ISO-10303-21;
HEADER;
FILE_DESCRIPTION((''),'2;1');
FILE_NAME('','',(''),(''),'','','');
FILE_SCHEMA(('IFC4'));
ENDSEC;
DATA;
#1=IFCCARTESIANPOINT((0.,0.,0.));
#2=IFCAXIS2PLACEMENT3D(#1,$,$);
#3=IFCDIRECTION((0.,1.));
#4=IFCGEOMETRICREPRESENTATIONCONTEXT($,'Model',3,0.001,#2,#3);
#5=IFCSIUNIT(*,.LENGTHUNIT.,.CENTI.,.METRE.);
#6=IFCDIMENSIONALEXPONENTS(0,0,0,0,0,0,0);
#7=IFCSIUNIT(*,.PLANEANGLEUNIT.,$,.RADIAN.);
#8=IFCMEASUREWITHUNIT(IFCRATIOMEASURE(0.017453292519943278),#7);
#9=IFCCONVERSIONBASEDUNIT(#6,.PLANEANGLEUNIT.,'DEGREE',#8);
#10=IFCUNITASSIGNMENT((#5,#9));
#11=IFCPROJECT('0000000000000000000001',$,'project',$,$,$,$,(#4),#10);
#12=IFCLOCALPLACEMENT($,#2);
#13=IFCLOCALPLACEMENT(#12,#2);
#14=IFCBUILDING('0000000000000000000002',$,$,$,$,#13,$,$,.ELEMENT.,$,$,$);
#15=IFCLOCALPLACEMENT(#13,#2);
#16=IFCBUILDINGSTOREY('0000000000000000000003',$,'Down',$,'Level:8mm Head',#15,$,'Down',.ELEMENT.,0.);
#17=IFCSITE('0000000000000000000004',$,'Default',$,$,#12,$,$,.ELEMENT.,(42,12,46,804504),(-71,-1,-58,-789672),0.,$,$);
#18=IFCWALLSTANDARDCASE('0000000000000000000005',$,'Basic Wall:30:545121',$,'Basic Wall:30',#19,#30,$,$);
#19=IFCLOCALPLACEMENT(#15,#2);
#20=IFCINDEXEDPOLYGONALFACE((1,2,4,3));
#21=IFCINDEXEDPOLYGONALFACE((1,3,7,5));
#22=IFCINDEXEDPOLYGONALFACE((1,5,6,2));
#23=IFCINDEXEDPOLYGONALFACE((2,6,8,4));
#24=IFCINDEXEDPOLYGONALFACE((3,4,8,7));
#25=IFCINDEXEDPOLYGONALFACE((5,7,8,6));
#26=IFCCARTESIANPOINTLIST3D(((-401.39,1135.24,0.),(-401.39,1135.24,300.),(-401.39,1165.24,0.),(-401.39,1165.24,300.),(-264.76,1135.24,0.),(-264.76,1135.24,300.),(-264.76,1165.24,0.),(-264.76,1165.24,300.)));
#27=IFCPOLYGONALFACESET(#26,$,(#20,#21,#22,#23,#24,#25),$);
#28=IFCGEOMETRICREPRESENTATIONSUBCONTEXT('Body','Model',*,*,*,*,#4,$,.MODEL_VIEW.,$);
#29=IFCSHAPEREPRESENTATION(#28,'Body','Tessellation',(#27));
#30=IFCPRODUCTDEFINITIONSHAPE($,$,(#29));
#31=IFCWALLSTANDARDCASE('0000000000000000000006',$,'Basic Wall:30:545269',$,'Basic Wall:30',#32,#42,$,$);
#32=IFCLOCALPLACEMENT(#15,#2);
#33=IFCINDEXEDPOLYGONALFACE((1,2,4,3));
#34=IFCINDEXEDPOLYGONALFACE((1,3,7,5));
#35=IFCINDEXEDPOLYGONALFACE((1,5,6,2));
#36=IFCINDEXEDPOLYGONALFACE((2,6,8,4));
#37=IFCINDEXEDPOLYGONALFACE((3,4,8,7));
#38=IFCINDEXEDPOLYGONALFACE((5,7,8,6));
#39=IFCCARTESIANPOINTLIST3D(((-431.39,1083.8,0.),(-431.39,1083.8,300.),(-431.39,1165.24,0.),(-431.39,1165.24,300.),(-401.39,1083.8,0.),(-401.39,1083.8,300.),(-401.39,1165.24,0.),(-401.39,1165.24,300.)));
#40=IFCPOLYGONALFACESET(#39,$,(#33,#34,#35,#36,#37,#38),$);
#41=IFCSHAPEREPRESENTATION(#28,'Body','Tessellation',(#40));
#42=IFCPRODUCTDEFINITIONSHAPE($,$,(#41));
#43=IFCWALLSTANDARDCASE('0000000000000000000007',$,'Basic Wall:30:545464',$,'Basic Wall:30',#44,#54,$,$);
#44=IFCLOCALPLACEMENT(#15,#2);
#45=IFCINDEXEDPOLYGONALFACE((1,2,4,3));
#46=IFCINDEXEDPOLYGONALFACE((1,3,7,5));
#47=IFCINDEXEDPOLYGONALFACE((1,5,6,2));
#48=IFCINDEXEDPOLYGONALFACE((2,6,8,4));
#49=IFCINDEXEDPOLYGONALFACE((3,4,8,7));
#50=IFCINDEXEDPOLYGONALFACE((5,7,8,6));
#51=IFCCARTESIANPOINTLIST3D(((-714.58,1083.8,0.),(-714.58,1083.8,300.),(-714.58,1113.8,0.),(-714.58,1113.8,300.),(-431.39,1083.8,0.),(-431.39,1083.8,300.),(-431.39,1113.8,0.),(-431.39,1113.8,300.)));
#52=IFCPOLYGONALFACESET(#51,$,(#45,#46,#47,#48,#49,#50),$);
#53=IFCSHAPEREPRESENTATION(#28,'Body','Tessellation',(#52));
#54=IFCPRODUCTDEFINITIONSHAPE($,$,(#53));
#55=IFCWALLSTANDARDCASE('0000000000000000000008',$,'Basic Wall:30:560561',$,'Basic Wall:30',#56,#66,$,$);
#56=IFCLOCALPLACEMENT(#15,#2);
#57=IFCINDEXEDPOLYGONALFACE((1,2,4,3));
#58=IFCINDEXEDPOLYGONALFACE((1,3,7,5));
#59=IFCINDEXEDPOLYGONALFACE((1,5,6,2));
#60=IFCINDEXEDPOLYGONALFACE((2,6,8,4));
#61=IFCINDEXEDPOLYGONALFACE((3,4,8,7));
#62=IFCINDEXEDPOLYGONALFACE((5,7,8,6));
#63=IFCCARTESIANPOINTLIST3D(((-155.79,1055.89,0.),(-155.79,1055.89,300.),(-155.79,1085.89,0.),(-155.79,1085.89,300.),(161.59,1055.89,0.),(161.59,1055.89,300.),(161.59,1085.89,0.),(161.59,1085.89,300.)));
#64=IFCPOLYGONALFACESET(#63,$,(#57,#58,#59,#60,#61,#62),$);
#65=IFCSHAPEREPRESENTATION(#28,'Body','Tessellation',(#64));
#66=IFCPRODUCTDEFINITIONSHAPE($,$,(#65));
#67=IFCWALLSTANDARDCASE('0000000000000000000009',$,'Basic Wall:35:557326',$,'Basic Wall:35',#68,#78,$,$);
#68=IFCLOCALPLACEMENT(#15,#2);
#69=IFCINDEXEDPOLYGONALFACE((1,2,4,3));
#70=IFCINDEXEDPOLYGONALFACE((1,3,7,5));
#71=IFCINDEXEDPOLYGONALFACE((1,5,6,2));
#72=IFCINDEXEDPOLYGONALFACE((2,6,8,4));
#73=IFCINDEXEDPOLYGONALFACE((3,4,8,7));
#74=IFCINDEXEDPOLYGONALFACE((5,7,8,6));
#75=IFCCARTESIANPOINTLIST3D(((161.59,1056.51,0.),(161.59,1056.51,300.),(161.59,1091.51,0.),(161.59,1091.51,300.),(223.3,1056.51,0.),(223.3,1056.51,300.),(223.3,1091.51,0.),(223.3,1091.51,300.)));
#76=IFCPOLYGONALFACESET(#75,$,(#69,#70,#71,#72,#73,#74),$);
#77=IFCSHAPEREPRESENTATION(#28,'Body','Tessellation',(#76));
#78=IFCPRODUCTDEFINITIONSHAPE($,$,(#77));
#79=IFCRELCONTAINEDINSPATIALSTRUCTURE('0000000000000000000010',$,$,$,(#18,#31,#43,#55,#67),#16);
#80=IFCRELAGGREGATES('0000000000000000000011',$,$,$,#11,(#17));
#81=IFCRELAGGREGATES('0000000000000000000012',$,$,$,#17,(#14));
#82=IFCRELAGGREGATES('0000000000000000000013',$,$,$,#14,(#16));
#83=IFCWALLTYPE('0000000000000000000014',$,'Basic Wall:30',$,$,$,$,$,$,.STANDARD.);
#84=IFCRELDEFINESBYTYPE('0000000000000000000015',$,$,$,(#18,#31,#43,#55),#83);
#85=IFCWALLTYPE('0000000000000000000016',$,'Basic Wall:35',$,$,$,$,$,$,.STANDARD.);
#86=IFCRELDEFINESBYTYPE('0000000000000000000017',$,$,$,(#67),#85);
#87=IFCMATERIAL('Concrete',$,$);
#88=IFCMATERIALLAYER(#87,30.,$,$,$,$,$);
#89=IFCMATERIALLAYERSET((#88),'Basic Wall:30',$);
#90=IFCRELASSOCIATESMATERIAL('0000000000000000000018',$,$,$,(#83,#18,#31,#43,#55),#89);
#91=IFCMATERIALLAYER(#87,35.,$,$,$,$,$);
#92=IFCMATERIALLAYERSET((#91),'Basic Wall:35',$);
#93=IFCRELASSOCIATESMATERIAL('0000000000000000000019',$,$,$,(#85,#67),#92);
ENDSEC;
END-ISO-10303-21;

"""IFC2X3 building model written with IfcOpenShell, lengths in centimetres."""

from ifc_helpers import new_model, entity, si_unit, converted_unit, direction, frame, frame_2d, origin, place, context, subcontext, project, spatial, rectangle, extrude, material, layer, layer_set, layer_usage, type_object, element, save


model = new_model("IFC2X3")

# Units and contexts
model_context = context("Model", 3, precision=0.001, world=origin(), true_north=direction((0.0, 1.0)))
body_context = subcontext(model_context, "Body", "Model", "MODEL_VIEW")
ifc_project = project(units=[si_unit("LENGTHUNIT", "METRE", prefix="CENTI"), converted_unit("PLANEANGLEUNIT", "DEGREE", entity("IfcRatioMeasure", 0.017453292519943278), si_unit("PLANEANGLEUNIT", "RADIAN"), dimensions=[0, 0, 0, 0, 0, 0, 0])], contexts=[model_context])

# Site, building, storey
site_placement = place(None, origin())
site = spatial("IfcSite", under=ifc_project, at=site_placement, Name="Default", CompositionType="ELEMENT", RefLatitude=(42, 12, 46, 804504), RefLongitude=(-71, -1, -58, -789672), RefElevation=0.0)
building_placement = place(site_placement, origin())
building = spatial("IfcBuilding", under=site, at=building_placement, CompositionType="ELEMENT")
storey_placement = place(building_placement, origin())
storey = spatial("IfcBuildingStorey", under=building, at=storey_placement, Name="Down", ObjectType="Level:8mm Head", LongName="Down", CompositionType="ELEMENT", Elevation=0.0)

# Shared definitions
ifc_material = material(Name="Concrete")

# Walls
ifc_layer_1 = layer(ifc_material, 30.0)
ifc_layer_set_1 = layer_set([ifc_layer_1], Name="Basic Wall:30")
wall_type_1 = type_object("IfcWallType", Name="Basic Wall:30", PredefinedType="STANDARD", material=ifc_layer_set_1)
ifc_layer_usage_1 = layer_usage(ifc_layer_set_1, "AXIS2", "POSITIVE", -15.0)
wall_1_placement = place(storey_placement, frame((-264.76, 1150.24, 0.0), z_axis=(0.0, 0.0, 1.0), x_axis=(-1.0, 0.0, 0.0)))
element("IfcWallStandardCase", 1, at=wall_1_placement, inside=storey, type_object=wall_type_1, material=ifc_layer_usage_1, Name="Basic Wall:30:545121", ObjectType="Basic Wall:30", context=body_context, shape_type="SweptSolid", body=[
    extrude(rectangle(XDim=136.63, YDim=30.0, at=frame_2d((68.32, 0.0), x_axis=(-1.0, 0.0))), origin(), (0.0, 0.0, 1.0), 300.0),
])
ifc_layer_usage_2 = layer_usage(ifc_layer_set_1, "AXIS2", "POSITIVE", -15.0)
wall_2_placement = place(storey_placement, frame((-416.39, 1083.8, 0.0), z_axis=(0.0, 0.0, 1.0), x_axis=(0.0, 1.0, 0.0)))
element("IfcWallStandardCase", 2, at=wall_2_placement, inside=storey, type_object=wall_type_1, material=ifc_layer_usage_2, Name="Basic Wall:30:545269", ObjectType="Basic Wall:30", context=body_context, shape_type="SweptSolid", body=[
    extrude(rectangle(XDim=81.45, YDim=30.0, at=frame_2d((40.72, 0.0), x_axis=(-1.0, 0.0))), origin(), (0.0, 0.0, 1.0), 300.0),
])
ifc_layer_usage_3 = layer_usage(ifc_layer_set_1, "AXIS2", "NEGATIVE", 15.0)
wall_3_placement = place(storey_placement, frame((-431.39, 1098.8, 0.0), z_axis=(0.0, 0.0, 1.0), x_axis=(-1.0, 0.0, 0.0)))
element("IfcWallStandardCase", 3, at=wall_3_placement, inside=storey, type_object=wall_type_1, material=ifc_layer_usage_3, Name="Basic Wall:30:545464", ObjectType="Basic Wall:30", context=body_context, shape_type="SweptSolid", body=[
    extrude(rectangle(XDim=283.19, YDim=30.0, at=frame_2d((141.59, 0.0), x_axis=(-1.0, 0.0))), origin(), (0.0, 0.0, 1.0), 300.0),
])
ifc_layer_usage_4 = layer_usage(ifc_layer_set_1, "AXIS2", "POSITIVE", -15.0)
wall_4_placement = place(storey_placement, frame((161.59, 1070.89, 0.0), z_axis=(0.0, 0.0, 1.0), x_axis=(-1.0, 0.0, 0.0)))
element("IfcWallStandardCase", 4, at=wall_4_placement, inside=storey, type_object=wall_type_1, material=ifc_layer_usage_4, Name="Basic Wall:30:560561", ObjectType="Basic Wall:30", context=body_context, shape_type="SweptSolid", body=[
    extrude(rectangle(XDim=317.38, YDim=30.0, at=frame_2d((158.69, 0.0), x_axis=(-1.0, 0.0))), origin(), (0.0, 0.0, 1.0), 300.0),
])
ifc_layer_2 = layer(ifc_material, 35.0)
ifc_layer_set_2 = layer_set([ifc_layer_2], Name="Basic Wall:35")
ifc_layer_usage_5 = layer_usage(ifc_layer_set_2, "AXIS2", "NEGATIVE", 17.5)
wall_type_2 = type_object("IfcWallType", Name="Basic Wall:35", PredefinedType="STANDARD", material=ifc_layer_set_2)
wall_5_placement = place(storey_placement, frame((223.3, 1074.01, 0.0), z_axis=(0.0, 0.0, 1.0), x_axis=(-1.0, 0.0, 0.0)))
element("IfcWallStandardCase", 5, at=wall_5_placement, inside=storey, type_object=wall_type_2, material=ifc_layer_usage_5, Name="Basic Wall:35:557326", ObjectType="Basic Wall:35", context=body_context, shape_type="SweptSolid", body=[
    extrude(rectangle(XDim=61.71, YDim=35.0, at=frame_2d((30.86, 0.0), x_axis=(-1.0, 0.0))), origin(), (0.0, 0.0, 1.0), 300.0),
])

save(model, "model.ifc")
